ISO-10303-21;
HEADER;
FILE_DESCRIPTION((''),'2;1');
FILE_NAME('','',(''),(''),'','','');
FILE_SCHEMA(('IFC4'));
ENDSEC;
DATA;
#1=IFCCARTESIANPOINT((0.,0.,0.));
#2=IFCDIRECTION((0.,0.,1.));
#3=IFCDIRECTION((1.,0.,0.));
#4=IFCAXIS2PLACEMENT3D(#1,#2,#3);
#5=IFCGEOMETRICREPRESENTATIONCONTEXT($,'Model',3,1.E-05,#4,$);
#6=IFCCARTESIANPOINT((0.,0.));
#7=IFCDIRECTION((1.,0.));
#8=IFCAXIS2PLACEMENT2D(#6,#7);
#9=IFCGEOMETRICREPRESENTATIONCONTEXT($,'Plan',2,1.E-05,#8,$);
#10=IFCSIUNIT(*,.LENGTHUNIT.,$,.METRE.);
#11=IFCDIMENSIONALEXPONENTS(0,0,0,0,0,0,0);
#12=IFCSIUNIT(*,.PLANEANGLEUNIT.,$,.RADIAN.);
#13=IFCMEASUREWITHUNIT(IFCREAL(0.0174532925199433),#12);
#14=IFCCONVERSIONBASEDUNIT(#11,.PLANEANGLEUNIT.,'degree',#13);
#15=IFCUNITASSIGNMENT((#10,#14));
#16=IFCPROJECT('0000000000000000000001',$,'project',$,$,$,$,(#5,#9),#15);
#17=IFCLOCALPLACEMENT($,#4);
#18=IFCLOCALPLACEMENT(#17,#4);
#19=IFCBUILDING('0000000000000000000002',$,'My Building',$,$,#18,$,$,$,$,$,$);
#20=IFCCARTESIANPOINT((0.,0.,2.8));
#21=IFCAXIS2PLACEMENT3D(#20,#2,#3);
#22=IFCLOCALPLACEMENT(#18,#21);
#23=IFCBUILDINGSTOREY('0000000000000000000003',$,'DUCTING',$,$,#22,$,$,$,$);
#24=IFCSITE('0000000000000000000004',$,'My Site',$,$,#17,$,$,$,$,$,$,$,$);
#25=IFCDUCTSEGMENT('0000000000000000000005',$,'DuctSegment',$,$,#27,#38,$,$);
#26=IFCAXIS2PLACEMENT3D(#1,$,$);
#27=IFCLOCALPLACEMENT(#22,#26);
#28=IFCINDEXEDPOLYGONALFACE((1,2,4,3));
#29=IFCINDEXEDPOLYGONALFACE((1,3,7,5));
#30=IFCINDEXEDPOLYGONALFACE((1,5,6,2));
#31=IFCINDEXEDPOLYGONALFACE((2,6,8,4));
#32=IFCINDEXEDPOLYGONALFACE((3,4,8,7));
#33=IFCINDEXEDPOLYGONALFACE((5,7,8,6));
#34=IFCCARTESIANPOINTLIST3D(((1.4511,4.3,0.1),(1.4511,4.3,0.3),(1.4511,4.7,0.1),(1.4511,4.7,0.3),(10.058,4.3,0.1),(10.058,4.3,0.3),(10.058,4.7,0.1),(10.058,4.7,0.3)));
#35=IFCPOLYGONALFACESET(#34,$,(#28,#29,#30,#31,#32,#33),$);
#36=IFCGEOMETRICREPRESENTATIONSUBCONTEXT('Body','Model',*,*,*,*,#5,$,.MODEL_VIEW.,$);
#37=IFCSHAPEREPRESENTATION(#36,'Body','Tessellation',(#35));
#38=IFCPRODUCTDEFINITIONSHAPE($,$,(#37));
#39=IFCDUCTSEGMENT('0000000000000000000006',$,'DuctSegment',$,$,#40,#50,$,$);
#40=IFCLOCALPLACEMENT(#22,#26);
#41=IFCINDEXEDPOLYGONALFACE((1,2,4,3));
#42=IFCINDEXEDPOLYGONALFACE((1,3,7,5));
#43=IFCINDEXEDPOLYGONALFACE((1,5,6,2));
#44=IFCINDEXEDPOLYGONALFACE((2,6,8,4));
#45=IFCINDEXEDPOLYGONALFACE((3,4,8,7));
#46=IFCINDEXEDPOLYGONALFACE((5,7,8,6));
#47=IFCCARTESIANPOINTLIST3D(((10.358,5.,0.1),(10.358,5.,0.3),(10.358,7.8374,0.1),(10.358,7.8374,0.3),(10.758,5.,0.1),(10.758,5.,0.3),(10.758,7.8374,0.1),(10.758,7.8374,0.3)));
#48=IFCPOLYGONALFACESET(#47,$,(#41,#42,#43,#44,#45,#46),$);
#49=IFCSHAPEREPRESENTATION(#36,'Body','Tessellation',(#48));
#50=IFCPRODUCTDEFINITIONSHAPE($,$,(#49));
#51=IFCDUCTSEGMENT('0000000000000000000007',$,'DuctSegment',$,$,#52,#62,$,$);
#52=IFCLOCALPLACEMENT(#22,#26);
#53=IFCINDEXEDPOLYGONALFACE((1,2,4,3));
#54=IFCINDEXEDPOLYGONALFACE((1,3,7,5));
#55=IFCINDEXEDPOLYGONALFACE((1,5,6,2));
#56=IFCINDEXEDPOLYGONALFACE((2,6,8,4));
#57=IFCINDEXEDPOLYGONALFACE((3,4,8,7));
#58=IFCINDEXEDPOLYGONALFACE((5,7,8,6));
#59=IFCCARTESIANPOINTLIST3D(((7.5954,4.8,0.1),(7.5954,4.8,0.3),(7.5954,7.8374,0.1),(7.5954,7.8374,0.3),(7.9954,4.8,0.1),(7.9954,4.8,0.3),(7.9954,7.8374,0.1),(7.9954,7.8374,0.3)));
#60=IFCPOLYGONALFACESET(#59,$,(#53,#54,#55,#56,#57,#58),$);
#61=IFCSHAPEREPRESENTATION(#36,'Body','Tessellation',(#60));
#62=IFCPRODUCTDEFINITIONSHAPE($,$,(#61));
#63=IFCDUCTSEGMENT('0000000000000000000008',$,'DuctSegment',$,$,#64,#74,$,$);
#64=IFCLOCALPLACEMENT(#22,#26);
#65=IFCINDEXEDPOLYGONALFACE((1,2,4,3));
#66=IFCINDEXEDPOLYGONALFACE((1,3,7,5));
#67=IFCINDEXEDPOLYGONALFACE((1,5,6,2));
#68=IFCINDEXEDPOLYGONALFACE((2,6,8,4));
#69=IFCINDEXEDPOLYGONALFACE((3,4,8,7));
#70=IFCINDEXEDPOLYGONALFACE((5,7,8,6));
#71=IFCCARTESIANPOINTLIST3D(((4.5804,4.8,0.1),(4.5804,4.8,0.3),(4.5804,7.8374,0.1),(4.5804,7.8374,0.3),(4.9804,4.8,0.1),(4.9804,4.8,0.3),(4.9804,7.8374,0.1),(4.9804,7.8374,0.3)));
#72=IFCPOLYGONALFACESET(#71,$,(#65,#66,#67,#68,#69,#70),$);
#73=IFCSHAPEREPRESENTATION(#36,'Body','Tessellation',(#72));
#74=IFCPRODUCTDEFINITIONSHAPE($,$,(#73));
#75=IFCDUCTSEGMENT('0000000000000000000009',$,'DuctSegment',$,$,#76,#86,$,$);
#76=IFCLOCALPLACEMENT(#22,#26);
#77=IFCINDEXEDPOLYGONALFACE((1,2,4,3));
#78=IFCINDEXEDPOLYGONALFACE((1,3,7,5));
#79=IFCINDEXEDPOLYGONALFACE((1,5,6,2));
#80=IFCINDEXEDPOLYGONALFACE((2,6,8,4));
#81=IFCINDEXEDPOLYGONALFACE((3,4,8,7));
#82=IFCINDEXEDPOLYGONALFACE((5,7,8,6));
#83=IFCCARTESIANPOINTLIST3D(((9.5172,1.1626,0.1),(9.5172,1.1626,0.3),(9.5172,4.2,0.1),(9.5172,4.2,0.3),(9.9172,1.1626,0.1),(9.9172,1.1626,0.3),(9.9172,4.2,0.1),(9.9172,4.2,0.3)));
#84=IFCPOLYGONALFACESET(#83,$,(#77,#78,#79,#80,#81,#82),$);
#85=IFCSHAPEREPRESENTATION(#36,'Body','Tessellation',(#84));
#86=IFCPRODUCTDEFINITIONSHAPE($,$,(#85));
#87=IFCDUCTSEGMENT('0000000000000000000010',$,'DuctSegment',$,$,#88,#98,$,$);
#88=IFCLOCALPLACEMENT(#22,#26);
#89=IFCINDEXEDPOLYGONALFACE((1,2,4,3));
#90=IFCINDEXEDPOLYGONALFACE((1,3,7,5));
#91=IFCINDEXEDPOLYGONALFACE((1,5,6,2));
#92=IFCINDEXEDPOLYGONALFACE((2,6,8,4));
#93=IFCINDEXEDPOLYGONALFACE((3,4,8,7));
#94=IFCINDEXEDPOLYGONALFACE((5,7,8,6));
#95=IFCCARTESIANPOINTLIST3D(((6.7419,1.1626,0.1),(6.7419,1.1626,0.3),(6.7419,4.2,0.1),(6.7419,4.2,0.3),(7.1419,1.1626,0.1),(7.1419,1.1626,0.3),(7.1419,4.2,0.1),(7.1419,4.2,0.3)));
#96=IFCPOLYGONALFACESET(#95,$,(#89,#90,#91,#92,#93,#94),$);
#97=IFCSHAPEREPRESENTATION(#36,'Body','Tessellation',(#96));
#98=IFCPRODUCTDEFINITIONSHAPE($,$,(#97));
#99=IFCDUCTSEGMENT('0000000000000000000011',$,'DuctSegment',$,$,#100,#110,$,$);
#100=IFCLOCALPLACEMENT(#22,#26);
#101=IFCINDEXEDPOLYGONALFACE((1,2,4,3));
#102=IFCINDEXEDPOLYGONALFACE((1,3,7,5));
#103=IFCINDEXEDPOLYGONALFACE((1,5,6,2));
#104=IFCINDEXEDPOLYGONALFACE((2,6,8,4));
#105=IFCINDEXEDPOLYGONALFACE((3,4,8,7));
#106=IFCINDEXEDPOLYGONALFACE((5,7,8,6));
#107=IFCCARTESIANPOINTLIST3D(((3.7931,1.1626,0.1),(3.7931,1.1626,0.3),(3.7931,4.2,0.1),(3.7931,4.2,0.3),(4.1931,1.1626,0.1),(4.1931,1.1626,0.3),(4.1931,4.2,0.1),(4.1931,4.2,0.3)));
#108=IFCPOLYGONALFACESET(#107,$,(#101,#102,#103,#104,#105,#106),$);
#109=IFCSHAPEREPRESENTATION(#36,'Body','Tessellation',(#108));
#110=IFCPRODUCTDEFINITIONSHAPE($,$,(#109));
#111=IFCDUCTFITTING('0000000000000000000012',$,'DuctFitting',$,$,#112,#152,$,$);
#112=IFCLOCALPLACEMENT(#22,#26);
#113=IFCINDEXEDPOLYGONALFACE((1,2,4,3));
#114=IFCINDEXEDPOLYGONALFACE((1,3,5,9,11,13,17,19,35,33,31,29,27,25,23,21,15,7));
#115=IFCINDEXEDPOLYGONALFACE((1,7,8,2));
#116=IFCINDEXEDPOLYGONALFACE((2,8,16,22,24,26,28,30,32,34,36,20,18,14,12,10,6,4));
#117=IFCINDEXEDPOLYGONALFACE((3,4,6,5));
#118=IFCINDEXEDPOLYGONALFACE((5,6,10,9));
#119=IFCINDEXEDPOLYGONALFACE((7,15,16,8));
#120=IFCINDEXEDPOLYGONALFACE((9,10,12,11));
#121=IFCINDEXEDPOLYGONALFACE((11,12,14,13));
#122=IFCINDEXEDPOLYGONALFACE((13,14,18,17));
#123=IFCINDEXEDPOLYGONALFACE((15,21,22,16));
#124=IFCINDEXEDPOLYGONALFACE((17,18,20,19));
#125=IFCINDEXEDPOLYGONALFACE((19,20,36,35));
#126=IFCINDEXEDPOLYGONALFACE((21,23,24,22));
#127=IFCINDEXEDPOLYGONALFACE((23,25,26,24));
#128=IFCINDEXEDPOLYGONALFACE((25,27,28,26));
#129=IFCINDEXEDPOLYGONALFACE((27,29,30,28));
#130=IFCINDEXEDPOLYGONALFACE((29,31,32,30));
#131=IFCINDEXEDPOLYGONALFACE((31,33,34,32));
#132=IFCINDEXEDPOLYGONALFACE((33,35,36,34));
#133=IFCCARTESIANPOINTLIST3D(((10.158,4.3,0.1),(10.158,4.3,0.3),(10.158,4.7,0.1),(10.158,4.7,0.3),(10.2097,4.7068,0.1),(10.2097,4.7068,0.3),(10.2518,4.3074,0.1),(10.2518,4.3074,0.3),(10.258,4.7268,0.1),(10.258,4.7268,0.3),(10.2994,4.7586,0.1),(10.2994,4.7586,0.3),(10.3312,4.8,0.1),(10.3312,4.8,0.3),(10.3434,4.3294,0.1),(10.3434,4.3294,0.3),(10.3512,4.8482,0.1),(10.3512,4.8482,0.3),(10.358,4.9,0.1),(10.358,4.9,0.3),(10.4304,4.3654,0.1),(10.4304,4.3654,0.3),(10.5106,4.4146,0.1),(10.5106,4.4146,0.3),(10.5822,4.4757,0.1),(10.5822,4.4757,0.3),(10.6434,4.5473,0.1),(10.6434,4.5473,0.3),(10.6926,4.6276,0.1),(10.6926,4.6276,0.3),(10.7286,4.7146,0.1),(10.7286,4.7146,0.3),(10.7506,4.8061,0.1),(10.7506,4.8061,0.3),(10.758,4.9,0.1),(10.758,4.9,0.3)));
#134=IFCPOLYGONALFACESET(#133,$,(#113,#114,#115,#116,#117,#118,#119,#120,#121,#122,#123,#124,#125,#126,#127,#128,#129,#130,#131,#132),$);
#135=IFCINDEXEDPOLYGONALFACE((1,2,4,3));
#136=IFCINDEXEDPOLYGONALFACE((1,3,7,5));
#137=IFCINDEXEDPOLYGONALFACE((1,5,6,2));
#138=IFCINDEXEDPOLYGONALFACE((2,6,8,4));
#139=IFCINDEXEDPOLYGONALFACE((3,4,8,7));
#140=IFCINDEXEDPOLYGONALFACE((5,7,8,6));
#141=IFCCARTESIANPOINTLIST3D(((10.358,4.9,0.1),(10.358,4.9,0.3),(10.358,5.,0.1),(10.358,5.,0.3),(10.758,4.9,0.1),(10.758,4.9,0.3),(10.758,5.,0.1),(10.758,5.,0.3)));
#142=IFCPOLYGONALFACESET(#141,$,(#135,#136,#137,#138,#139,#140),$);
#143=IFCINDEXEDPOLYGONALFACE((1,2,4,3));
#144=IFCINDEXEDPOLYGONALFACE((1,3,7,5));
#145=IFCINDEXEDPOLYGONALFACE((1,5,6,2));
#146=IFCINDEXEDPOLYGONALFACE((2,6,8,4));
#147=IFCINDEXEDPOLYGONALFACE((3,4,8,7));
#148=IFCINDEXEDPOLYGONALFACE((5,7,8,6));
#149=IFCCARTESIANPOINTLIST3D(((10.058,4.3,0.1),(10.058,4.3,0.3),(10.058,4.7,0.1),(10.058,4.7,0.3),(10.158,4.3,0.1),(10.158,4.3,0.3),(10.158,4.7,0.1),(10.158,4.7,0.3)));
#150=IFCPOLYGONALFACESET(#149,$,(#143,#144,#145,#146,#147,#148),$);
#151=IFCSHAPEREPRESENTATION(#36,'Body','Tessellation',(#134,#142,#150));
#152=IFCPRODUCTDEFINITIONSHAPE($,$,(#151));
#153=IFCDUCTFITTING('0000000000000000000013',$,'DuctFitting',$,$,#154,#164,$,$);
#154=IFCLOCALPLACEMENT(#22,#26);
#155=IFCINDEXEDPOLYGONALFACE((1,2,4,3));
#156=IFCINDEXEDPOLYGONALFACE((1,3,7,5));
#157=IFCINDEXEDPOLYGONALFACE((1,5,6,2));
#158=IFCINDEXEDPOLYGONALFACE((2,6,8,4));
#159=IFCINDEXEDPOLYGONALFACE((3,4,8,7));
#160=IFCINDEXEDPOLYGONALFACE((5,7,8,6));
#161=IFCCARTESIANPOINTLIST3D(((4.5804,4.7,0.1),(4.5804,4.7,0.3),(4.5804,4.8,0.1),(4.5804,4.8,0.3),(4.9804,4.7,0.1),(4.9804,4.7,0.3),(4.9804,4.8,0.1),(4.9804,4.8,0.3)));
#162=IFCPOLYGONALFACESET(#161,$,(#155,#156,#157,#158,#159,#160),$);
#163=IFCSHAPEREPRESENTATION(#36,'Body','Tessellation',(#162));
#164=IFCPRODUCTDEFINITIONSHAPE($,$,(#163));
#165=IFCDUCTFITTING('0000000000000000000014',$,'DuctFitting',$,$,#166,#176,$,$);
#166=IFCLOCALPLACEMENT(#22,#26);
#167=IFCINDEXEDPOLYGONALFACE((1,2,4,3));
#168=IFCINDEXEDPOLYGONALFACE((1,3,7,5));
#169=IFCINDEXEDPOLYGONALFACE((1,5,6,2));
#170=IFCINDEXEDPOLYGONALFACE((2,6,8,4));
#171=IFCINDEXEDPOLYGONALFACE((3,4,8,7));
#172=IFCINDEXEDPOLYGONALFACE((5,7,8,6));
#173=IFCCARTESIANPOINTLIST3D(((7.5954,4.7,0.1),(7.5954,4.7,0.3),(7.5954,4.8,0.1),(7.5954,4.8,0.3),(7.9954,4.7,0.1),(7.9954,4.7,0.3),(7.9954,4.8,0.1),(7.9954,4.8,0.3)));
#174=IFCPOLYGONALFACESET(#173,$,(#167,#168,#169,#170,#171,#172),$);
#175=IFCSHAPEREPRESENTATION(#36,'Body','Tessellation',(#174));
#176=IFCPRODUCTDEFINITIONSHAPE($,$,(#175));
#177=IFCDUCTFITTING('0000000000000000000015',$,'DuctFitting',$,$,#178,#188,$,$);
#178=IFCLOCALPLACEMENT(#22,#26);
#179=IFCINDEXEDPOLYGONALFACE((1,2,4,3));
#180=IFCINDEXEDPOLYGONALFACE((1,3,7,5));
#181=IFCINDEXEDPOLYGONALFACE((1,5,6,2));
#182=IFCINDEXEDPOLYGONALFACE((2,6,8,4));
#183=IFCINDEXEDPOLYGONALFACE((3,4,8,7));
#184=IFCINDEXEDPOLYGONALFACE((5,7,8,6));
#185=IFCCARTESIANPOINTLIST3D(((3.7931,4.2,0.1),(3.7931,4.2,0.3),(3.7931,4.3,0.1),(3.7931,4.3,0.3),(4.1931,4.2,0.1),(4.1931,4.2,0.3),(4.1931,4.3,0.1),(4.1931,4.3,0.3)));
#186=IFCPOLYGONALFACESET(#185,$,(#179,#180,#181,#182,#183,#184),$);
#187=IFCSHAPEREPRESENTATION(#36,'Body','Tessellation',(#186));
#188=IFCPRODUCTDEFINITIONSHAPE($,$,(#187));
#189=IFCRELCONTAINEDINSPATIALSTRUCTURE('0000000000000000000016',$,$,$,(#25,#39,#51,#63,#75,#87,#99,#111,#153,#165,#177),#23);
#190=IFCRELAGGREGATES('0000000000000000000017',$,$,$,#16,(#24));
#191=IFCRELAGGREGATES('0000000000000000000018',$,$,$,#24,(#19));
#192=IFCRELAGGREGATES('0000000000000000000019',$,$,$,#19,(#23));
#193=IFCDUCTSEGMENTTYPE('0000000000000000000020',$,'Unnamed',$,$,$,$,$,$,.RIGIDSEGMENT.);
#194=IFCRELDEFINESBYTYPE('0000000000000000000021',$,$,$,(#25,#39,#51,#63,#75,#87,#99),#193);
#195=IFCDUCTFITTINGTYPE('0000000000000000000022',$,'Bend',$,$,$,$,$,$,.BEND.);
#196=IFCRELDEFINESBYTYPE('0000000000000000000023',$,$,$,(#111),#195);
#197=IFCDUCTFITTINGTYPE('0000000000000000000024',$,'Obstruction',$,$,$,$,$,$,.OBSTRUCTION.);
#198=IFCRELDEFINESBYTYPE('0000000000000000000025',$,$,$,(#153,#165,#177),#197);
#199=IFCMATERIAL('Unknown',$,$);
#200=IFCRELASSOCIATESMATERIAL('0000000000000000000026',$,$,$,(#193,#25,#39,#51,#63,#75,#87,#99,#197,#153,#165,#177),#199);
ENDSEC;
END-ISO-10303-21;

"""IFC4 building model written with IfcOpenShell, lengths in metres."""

from ifc_helpers import new_model, entity, si_unit, converted_unit, frame, origin_with_axes, origin_2d_with_axis, place, context, subcontext, project, spatial, line, arc, indexed_curve, rectangle, outline, extrude, source, transform, mapped, material, material_profile, profile_set, profile_usage, type_object, type_shapes, element, save


model = new_model("IFC4")

# Units and contexts
model_context = context("Model", 3, precision=1e-05, world=origin_with_axes())
plan_context = context("Plan", 2, precision=1e-05, world=origin_2d_with_axis())
body_context = subcontext(model_context, "Body", "Model", "MODEL_VIEW")
ifc_project = project(units=[si_unit("LENGTHUNIT", "METRE"), converted_unit("PLANEANGLEUNIT", "degree", entity("IfcReal", 0.0174532925199433), si_unit("PLANEANGLEUNIT", "RADIAN"), dimensions=[0, 0, 0, 0, 0, 0, 0])], contexts=[model_context, plan_context])

# Site, building, storey
site_placement = place(None, origin_with_axes())
site = spatial("IfcSite", under=ifc_project, at=site_placement, Name="My Site")
building_placement = place(site_placement, origin_with_axes())
building = spatial("IfcBuilding", under=site, at=building_placement, Name="My Building")
storey_placement = place(building_placement, frame((0.0, 0.0, 2.8), z_axis=(0.0, 0.0, 1.0), x_axis=(1.0, 0.0, 0.0)))
storey = spatial("IfcBuildingStorey", under=building, at=storey_placement, Name="DUCTING")

# Duct segments
ifc_material = material(Name="Unknown")
ifc_material_profile_1 = material_profile(ifc_material, rectangle(XDim=0.4, YDim=0.2))
ifc_profile_set_1 = profile_set([ifc_material_profile_1])
ifc_profile_usage_1 = profile_usage(ifc_profile_set_1, cardinal=5)
duct_segment_type = type_object("IfcDuctSegmentType", Name="Unnamed", PredefinedType="RIGIDSEGMENT", material=ifc_profile_set_1)
duct_segment_1_placement = place(storey_placement, frame((1.4511, 4.5, 0.2), z_axis=(1.0, 0.0, 0.0), x_axis=(0.0, 1.0, 0.0)))
element("IfcDuctSegment", 1, at=duct_segment_1_placement, inside=storey, type_object=duct_segment_type, material=ifc_profile_usage_1, Name="DuctSegment", context=body_context, shape_type="SweptSolid", body=[
    extrude(rectangle(XDim=0.4, YDim=0.2), origin_with_axes(), (0.0, 0.0, 1.0), 8.6069),
])
ifc_profile_usage_2 = profile_usage(ifc_profile_set_1, cardinal=5)
duct_segment_2_placement = place(storey_placement, frame((10.558, 5.0, 0.2), z_axis=(0.0, 1.0, 0.0), x_axis=(-1.0, 0.0, 0.0)))
element("IfcDuctSegment", 2, at=duct_segment_2_placement, inside=storey, type_object=duct_segment_type, material=ifc_profile_usage_2, Name="DuctSegment", context=body_context, shape_type="SweptSolid", body=[
    extrude(rectangle(XDim=0.4, YDim=0.2), origin_with_axes(), (0.0, 0.0, 1.0), 2.8374),
])
ifc_profile_usage_3 = profile_usage(ifc_profile_set_1, cardinal=5)
duct_segment_3_placement = place(storey_placement, frame((7.7954, 4.8, 0.2), z_axis=(0.0, 1.0, 0.0), x_axis=(-1.0, 0.0, 0.0)))
element("IfcDuctSegment", 3, at=duct_segment_3_placement, inside=storey, type_object=duct_segment_type, material=ifc_profile_usage_3, Name="DuctSegment", context=body_context, shape_type="SweptSolid", body=[
    extrude(rectangle(XDim=0.4, YDim=0.2), origin_with_axes(), (0.0, 0.0, 1.0), 3.0374),
])
ifc_profile_usage_4 = profile_usage(ifc_profile_set_1, cardinal=5)
duct_segment_4_placement = place(storey_placement, frame((4.7804, 4.8, 0.2), z_axis=(0.0, 1.0, 0.0), x_axis=(-1.0, 0.0, 0.0)))
element("IfcDuctSegment", 4, at=duct_segment_4_placement, inside=storey, type_object=duct_segment_type, material=ifc_profile_usage_4, Name="DuctSegment", context=body_context, shape_type="SweptSolid", body=[
    extrude(rectangle(XDim=0.4, YDim=0.2), origin_with_axes(), (0.0, 0.0, 1.0), 3.0374),
])
ifc_profile_usage_5 = profile_usage(ifc_profile_set_1, cardinal=5)
duct_segment_5_placement = place(storey_placement, frame((9.7172, 4.2, 0.2), z_axis=(0.0, -1.0, 0.0), x_axis=(1.0, 0.0, 0.0)))
element("IfcDuctSegment", 5, at=duct_segment_5_placement, inside=storey, type_object=duct_segment_type, material=ifc_profile_usage_5, Name="DuctSegment", context=body_context, shape_type="SweptSolid", body=[
    extrude(rectangle(XDim=0.4, YDim=0.2), origin_with_axes(), (0.0, 0.0, 1.0), 3.0374),
])
ifc_profile_usage_6 = profile_usage(ifc_profile_set_1, cardinal=5)
duct_segment_6_placement = place(storey_placement, frame((6.9419, 4.2, 0.2), z_axis=(0.0, -1.0, 0.0), x_axis=(1.0, 0.0, 0.0)))
element("IfcDuctSegment", 6, at=duct_segment_6_placement, inside=storey, type_object=duct_segment_type, material=ifc_profile_usage_6, Name="DuctSegment", context=body_context, shape_type="SweptSolid", body=[
    extrude(rectangle(XDim=0.4, YDim=0.2), origin_with_axes(), (0.0, 0.0, 1.0), 3.0374),
])
ifc_profile_usage_7 = profile_usage(ifc_profile_set_1, cardinal=5)
duct_segment_7_placement = place(storey_placement, frame((3.9931, 4.2, 0.2), z_axis=(0.0, -1.0, 0.0), x_axis=(1.0, 0.0, 0.0)))
element("IfcDuctSegment", 7, at=duct_segment_7_placement, inside=storey, type_object=duct_segment_type, material=ifc_profile_usage_7, Name="DuctSegment", context=body_context, shape_type="SweptSolid", body=[
    extrude(rectangle(XDim=0.4, YDim=0.2), origin_with_axes(), (0.0, 0.0, 1.0), 3.0374),
])

# Duct fittings
duct_fitting_type_1 = type_object("IfcDuctFittingType", Name="Bend", PredefinedType="BEND")
shared_shape = source(origin_with_axes(), body_context, "Body", "SweptSolid", [
    extrude(outline(indexed_curve([(0.2, 0.0), (0.2586, -0.1414), (0.4, -0.2), (0.4, -0.6), (-0.0243, -0.4243), (-0.2, 0.0)], segments=[arc(1, 2, 3), line(3, 4), arc(4, 5, 6), line(6, 1)])), frame((0.0, -0.1, -0.1), z_axis=(0.0, -1.0, 0.0), x_axis=(1.0, 0.0, 0.0)), (0.0, 0.0, -1.0), 0.2),
    extrude(rectangle(XDim=0.4, YDim=0.2), origin_with_axes(), (0.0, 0.0, -1.0), 0.1),
    extrude(rectangle(XDim=0.4, YDim=0.2), frame((0.4, 0.0, -0.5), z_axis=(1.0, 0.0, 0.0), x_axis=(0.0, 0.0, 1.0)), (0.0, 0.0, 1.0), 0.1),
])
type_shapes(duct_fitting_type_1, [shared_shape])
duct_fitting_1_placement = place(storey_placement, frame((10.558, 5.0, 0.2), z_axis=(0.0, 1.0, 0.0), x_axis=(-1.0, 0.0, 0.0)))
element("IfcDuctFitting", 8, at=duct_fitting_1_placement, inside=storey, type_object=duct_fitting_type_1, Name="DuctFitting", context=body_context, shape_type="MappedRepresentation", body=[
    mapped(shared_shape, transform((0.0, 0.0, 0.0), x_axis=(1.0, 0.0, 0.0), y_axis=(0.0, 1.0, 0.0), z_axis=(0.0, 0.0, 1.0), scale=1.0)),
])
ifc_material_profile_2 = material_profile(ifc_material, rectangle(XDim=0.4, YDim=0.2))
ifc_profile_set_2 = profile_set([ifc_material_profile_2])
ifc_profile_usage_8 = profile_usage(ifc_profile_set_2, cardinal=5)
duct_fitting_type_2 = type_object("IfcDuctFittingType", Name="Obstruction", PredefinedType="OBSTRUCTION", material=ifc_profile_set_2)
duct_fitting_2_placement = place(storey_placement, frame((4.7804, 4.7, 0.2), z_axis=(0.0, 1.0, 0.0), x_axis=(-1.0, 0.0, 0.0)))
element("IfcDuctFitting", 9, at=duct_fitting_2_placement, inside=storey, type_object=duct_fitting_type_2, material=ifc_profile_usage_8, Name="DuctFitting", context=body_context, shape_type="SweptSolid", body=[
    extrude(rectangle(XDim=0.4, YDim=0.2), origin_with_axes(), (0.0, 0.0, 1.0), 0.1),
])
ifc_profile_usage_9 = profile_usage(ifc_profile_set_2, cardinal=5)
duct_fitting_3_placement = place(storey_placement, frame((7.7954, 4.7, 0.2), z_axis=(0.0, 1.0, 0.0), x_axis=(-1.0, 0.0, 0.0)))
element("IfcDuctFitting", 10, at=duct_fitting_3_placement, inside=storey, type_object=duct_fitting_type_2, material=ifc_profile_usage_9, Name="DuctFitting", context=body_context, shape_type="SweptSolid", body=[
    extrude(rectangle(XDim=0.4, YDim=0.2), origin_with_axes(), (0.0, 0.0, 1.0), 0.1),
])
ifc_profile_usage_10 = profile_usage(ifc_profile_set_2, cardinal=5)
duct_fitting_4_placement = place(storey_placement, frame((3.9931, 4.3, 0.2), z_axis=(0.0, -1.0, 0.0), x_axis=(1.0, 0.0, 0.0)))
element("IfcDuctFitting", 11, at=duct_fitting_4_placement, inside=storey, type_object=duct_fitting_type_2, material=ifc_profile_usage_10, Name="DuctFitting", context=body_context, shape_type="SweptSolid", body=[
    extrude(rectangle(XDim=0.4, YDim=0.2), origin_with_axes(), (0.0, 0.0, 1.0), 0.1),
])

save(model, "model.ifc")
